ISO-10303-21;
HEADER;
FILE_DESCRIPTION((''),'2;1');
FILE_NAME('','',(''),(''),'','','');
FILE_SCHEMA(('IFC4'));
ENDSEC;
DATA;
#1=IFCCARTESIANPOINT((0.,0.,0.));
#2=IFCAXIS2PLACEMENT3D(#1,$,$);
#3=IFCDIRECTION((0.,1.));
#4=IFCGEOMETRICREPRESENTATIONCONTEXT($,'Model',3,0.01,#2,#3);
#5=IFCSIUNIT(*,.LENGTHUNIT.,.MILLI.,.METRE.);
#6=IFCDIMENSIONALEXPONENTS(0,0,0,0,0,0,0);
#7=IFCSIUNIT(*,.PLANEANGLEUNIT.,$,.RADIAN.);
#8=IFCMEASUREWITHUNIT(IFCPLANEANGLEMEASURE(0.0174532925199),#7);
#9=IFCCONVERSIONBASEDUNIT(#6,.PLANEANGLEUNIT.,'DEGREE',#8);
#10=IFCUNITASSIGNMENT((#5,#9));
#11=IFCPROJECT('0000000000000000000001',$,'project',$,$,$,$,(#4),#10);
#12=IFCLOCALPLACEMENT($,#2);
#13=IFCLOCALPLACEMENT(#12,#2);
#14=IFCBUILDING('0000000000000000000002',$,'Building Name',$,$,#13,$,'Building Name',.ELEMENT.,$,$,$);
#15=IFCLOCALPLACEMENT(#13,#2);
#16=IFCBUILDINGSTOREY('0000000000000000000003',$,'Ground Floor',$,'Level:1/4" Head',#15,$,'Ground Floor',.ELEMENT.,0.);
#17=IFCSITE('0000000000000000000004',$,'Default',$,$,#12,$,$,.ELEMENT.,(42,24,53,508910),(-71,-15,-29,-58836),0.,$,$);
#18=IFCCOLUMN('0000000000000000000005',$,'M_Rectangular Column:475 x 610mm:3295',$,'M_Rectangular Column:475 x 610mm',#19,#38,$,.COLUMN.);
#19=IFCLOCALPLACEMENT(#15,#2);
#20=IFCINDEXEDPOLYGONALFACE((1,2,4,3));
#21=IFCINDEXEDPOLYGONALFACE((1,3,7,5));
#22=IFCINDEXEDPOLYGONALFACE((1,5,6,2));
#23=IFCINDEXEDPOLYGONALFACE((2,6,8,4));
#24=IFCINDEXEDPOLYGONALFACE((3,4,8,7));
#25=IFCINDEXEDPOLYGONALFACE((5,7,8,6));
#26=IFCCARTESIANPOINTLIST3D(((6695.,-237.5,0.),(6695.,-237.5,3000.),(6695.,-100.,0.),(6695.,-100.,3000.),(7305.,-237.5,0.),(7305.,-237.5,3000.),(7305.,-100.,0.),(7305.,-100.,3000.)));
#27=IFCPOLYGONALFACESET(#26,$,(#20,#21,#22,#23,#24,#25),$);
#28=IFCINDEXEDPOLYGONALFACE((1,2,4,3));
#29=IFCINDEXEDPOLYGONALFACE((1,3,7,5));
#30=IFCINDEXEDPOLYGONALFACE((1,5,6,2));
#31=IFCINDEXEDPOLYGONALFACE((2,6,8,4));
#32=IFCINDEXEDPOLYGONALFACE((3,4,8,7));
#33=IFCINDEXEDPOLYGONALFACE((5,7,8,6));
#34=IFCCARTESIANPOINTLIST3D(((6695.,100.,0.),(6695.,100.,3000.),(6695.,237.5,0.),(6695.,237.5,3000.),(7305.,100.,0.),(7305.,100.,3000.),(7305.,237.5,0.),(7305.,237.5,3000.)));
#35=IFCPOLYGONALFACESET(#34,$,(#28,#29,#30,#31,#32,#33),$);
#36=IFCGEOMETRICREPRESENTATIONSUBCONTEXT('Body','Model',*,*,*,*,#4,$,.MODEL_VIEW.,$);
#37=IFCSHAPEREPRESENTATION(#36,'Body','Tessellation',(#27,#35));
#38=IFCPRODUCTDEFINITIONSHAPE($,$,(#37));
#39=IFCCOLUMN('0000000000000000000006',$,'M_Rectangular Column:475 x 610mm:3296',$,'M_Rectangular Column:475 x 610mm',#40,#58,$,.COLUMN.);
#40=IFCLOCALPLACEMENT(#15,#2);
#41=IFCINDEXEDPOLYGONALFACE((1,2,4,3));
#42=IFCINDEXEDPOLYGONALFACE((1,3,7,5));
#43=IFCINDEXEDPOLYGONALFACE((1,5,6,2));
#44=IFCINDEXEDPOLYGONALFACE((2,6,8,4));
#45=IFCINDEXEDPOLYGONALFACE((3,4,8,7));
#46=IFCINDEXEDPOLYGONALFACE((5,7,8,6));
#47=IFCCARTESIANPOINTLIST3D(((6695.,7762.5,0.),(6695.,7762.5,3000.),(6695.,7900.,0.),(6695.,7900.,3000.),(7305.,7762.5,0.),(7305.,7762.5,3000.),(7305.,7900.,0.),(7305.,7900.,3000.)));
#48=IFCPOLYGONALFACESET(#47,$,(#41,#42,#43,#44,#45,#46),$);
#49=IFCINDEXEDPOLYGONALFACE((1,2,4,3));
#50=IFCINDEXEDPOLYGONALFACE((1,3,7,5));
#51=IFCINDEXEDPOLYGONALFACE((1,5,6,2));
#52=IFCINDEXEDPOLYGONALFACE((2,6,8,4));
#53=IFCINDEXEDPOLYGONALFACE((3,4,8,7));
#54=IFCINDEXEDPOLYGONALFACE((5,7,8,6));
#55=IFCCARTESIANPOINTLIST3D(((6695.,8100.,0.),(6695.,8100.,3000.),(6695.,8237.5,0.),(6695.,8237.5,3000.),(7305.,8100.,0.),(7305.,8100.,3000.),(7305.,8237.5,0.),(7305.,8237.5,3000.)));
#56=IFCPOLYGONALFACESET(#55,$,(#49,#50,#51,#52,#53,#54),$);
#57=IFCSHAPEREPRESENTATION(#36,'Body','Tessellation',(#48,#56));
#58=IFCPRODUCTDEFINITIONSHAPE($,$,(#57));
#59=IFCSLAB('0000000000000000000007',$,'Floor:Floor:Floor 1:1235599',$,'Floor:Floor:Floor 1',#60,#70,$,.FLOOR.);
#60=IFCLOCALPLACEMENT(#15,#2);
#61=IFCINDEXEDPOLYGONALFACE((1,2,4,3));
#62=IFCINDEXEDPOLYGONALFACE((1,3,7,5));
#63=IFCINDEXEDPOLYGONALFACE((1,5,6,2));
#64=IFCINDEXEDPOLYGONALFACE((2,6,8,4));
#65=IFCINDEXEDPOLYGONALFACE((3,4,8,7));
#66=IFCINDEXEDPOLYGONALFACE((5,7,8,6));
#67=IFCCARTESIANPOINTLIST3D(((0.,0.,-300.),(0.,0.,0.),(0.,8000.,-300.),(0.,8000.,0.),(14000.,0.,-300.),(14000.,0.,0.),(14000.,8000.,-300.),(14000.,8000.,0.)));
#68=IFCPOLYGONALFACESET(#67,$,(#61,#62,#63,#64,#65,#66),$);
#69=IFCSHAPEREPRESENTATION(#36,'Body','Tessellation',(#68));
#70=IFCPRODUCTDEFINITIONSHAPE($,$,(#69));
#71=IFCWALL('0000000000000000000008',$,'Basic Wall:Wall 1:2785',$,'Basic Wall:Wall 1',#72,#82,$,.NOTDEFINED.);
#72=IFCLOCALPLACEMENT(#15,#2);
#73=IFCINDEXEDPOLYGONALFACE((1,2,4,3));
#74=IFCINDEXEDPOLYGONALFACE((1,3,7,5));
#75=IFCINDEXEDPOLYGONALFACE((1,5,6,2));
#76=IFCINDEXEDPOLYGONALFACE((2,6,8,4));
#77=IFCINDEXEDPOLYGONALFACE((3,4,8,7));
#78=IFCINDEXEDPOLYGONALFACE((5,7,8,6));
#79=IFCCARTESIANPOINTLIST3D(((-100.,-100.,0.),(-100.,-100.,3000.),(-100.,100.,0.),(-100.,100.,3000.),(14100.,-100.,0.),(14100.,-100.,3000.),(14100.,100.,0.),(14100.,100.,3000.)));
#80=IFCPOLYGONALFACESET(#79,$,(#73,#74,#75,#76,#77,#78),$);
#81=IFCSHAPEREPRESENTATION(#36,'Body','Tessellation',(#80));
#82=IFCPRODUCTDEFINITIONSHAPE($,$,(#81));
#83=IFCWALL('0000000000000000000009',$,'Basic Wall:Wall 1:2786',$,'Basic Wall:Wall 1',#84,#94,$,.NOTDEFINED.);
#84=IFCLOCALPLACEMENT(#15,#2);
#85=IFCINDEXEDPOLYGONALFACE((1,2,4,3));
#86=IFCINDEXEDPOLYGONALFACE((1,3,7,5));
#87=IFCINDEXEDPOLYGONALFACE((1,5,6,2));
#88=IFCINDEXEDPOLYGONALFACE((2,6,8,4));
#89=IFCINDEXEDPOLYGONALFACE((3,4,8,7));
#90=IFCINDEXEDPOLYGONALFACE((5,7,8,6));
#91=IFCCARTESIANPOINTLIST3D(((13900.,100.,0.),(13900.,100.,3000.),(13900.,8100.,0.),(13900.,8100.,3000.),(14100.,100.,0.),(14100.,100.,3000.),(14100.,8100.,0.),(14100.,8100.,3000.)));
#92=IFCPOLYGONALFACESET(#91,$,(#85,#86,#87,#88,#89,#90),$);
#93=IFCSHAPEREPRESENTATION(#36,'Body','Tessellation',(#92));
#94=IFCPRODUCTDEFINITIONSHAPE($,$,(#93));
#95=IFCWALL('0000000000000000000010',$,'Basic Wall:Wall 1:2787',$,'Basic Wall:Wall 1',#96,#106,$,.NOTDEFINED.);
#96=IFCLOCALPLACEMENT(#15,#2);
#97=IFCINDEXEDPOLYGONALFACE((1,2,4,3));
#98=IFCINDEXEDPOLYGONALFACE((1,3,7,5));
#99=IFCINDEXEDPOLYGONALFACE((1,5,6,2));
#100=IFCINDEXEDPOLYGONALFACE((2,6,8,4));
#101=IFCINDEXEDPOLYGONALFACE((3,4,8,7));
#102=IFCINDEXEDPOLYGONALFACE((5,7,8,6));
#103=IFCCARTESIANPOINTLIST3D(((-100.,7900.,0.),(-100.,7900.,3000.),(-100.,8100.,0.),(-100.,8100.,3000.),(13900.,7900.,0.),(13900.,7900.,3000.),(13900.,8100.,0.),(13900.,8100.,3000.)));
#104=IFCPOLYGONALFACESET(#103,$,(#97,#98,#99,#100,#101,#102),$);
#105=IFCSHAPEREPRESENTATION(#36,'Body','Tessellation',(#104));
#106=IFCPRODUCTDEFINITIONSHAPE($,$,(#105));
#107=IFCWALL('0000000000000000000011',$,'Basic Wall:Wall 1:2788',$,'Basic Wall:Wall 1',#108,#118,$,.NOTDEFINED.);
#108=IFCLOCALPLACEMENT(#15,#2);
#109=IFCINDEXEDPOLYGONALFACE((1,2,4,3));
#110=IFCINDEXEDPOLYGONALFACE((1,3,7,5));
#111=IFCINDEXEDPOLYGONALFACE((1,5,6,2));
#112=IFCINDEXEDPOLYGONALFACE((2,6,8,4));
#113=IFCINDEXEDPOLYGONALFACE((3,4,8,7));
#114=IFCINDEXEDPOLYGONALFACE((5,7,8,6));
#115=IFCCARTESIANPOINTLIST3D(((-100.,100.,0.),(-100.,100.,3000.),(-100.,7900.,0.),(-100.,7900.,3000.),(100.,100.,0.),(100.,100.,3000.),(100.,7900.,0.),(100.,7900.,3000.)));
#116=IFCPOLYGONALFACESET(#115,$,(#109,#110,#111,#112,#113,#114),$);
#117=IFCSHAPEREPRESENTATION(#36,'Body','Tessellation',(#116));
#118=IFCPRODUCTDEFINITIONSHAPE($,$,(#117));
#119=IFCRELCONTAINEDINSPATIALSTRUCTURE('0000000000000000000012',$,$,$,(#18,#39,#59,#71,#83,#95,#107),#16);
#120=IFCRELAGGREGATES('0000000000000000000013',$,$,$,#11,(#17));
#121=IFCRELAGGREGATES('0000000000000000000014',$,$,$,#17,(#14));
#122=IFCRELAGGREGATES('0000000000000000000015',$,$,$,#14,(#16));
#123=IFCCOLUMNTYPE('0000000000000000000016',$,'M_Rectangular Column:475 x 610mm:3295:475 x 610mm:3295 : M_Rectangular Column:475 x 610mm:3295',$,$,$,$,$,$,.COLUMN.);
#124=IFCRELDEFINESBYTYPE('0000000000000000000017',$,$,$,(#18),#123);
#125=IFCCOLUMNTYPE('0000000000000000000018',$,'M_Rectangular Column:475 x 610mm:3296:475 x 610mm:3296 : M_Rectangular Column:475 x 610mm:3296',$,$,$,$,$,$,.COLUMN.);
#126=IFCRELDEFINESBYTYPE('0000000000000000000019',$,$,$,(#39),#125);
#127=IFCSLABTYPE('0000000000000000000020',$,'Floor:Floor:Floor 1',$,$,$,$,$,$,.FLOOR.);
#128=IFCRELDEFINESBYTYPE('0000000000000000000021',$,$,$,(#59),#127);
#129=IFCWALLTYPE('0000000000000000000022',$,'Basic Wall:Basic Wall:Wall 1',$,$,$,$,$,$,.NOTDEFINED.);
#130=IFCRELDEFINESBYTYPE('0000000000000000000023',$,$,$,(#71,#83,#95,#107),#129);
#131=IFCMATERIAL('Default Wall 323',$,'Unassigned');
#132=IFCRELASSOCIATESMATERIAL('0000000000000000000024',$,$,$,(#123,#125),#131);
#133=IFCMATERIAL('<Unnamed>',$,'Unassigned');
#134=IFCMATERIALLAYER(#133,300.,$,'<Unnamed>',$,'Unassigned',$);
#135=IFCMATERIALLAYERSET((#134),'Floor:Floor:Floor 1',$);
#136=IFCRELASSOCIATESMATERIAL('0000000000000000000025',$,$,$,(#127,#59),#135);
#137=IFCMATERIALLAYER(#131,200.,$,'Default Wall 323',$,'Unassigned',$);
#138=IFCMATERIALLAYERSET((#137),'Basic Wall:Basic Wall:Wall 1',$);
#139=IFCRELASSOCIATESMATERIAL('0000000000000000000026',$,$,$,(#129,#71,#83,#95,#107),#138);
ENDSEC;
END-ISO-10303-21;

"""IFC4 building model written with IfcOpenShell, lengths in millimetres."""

from ifc_helpers import new_model, entity, si_unit, converted_unit, direction, frame, frame_2d, origin, origin_2d_with_axis, place, context, subcontext, project, spatial, rectangle, extrude, source, transform, mapped, material, layer, layer_set, layer_usage, material_profile, profile_set, type_object, type_shapes, element, save


model = new_model("IFC4")

# Units and contexts
model_context = context("Model", 3, precision=0.01, world=origin(), true_north=direction((0.0, 1.0)))
body_context = subcontext(model_context, "Body", "Model", "MODEL_VIEW")
ifc_project = project(units=[si_unit("LENGTHUNIT", "METRE", prefix="MILLI"), converted_unit("PLANEANGLEUNIT", "DEGREE", entity("IfcPlaneAngleMeasure", 0.0174532925199), si_unit("PLANEANGLEUNIT", "RADIAN"), dimensions=[0, 0, 0, 0, 0, 0, 0])], contexts=[model_context])

# Site, building, storey
site_placement = place(None, origin())
site = spatial("IfcSite", under=ifc_project, at=site_placement, Name="Default", CompositionType="ELEMENT", RefLatitude=(42, 24, 53, 508910), RefLongitude=(-71, -15, -29, -58836), RefElevation=0.0)
building_placement = place(site_placement, origin())
building = spatial("IfcBuilding", under=site, at=building_placement, Name="Building Name", LongName="Building Name", CompositionType="ELEMENT")
storey_placement = place(building_placement, origin())
storey = spatial("IfcBuildingStorey", under=building, at=storey_placement, Name="Ground Floor", ObjectType="Level:1/4\" Head", LongName="Ground Floor", CompositionType="ELEMENT", Elevation=0.0)

# Columns
ifc_material_1 = material(Name="Default Wall 323", Category="Unassigned")
ifc_material_profile_1 = material_profile(ifc_material_1, rectangle(XDim=610.0, YDim=137.5, at=origin_2d_with_axis()), Name="475 x 610mm:3295 : M_Rectangular Column:475 x 610mm:3295")
ifc_material_profile_2 = material_profile(ifc_material_1, rectangle(XDim=610.0, YDim=137.5, at=frame_2d((0.0, 0.0), x_axis=(1.0, 0.0))), Name="475 x 610mm:3295 : M_Rectangular Column:475 x 610mm:3295")
ifc_profile_set_1 = profile_set([ifc_material_profile_1, ifc_material_profile_2], Name="475 x 610mm:3295 : M_Rectangular Column:475 x 610mm:3295")
column_type_1 = type_object("IfcColumnType", Name="M_Rectangular Column:475 x 610mm:3295:475 x 610mm:3295 : M_Rectangular Column:475 x 610mm:3295", PredefinedType="COLUMN", material=ifc_profile_set_1)
shared_shape_1 = source(origin(), body_context, "Body", "SweptSolid", [
    extrude(rectangle(XDim=610.0, YDim=137.5, at=origin_2d_with_axis()), frame((7000.0, -168.8, 0.0), z_axis=(0.0, 0.0, 1.0), x_axis=(-1.0, 0.0, 0.0)), (0.0, 0.0, 1.0), 3000.0),
    extrude(rectangle(XDim=610.0, YDim=137.5, at=frame_2d((0.0, 0.0), x_axis=(1.0, 0.0))), frame((7000.0, 168.8, 0.0)), (0.0, 0.0, 1.0), 3000.0),
])
type_shapes(column_type_1, [shared_shape_1])
column_1_placement = place(storey_placement, origin())
element("IfcColumn", 1, at=column_1_placement, inside=storey, type_object=column_type_1, Name="M_Rectangular Column:475 x 610mm:3295", ObjectType="M_Rectangular Column:475 x 610mm", PredefinedType="COLUMN", context=body_context, shape_type="MappedRepresentation", body=[
    mapped(shared_shape_1, transform((0.0, 0.0, 0.0), scale=1.0)),
])
ifc_material_profile_3 = material_profile(ifc_material_1, rectangle(XDim=610.0, YDim=137.5, at=frame_2d((0.0, 0.0), x_axis=(1.0, 0.0))), Name="475 x 610mm:3296 : M_Rectangular Column:475 x 610mm:3296")
ifc_material_profile_4 = material_profile(ifc_material_1, rectangle(XDim=610.0, YDim=137.5, at=frame_2d((0.0, 0.0), x_axis=(1.0, 0.0))), Name="475 x 610mm:3296 : M_Rectangular Column:475 x 610mm:3296")
ifc_profile_set_2 = profile_set([ifc_material_profile_3, ifc_material_profile_4], Name="475 x 610mm:3296 : M_Rectangular Column:475 x 610mm:3296")
column_type_2 = type_object("IfcColumnType", Name="M_Rectangular Column:475 x 610mm:3296:475 x 610mm:3296 : M_Rectangular Column:475 x 610mm:3296", PredefinedType="COLUMN", material=ifc_profile_set_2)
shared_shape_2 = source(origin(), body_context, "Body", "SweptSolid", [
    extrude(rectangle(XDim=610.0, YDim=137.5, at=frame_2d((0.0, 0.0), x_axis=(1.0, 0.0))), frame((7000.0, 7831.2, 0.0), z_axis=(0.0, 0.0, 1.0), x_axis=(-1.0, 0.0, 0.0)), (0.0, 0.0, 1.0), 3000.0),
    extrude(rectangle(XDim=610.0, YDim=137.5, at=frame_2d((0.0, 0.0), x_axis=(1.0, 0.0))), frame((7000.0, 8168.8, 0.0)), (0.0, 0.0, 1.0), 3000.0),
])
type_shapes(column_type_2, [shared_shape_2])
column_2_placement = place(storey_placement, origin())
element("IfcColumn", 2, at=column_2_placement, inside=storey, type_object=column_type_2, Name="M_Rectangular Column:475 x 610mm:3296", ObjectType="M_Rectangular Column:475 x 610mm", PredefinedType="COLUMN", context=body_context, shape_type="MappedRepresentation", body=[
    mapped(shared_shape_2, transform((0.0, 0.0, 0.0), scale=1.0)),
])

# Slab
ifc_material_2 = material(Name="<Unnamed>", Category="Unassigned")
ifc_layer_1 = layer(ifc_material_2, 300.0, Name="<Unnamed>", Category="Unassigned")
ifc_layer_set_1 = layer_set([ifc_layer_1], Name="Floor:Floor:Floor 1")
ifc_layer_usage_1 = layer_usage(ifc_layer_set_1, "AXIS3", "POSITIVE", 0.0)
slab_type = type_object("IfcSlabType", Name="Floor:Floor:Floor 1", PredefinedType="FLOOR", material=ifc_layer_set_1)
slab_placement = place(storey_placement, origin())
element("IfcSlab", 3, at=slab_placement, inside=storey, type_object=slab_type, material=ifc_layer_usage_1, Name="Floor:Floor:Floor 1:1235599", ObjectType="Floor:Floor:Floor 1", PredefinedType="FLOOR", context=body_context, shape_type="SweptSolid", body=[
    extrude(rectangle(XDim=8000.0, YDim=14000.0, at=origin_2d_with_axis()), frame((7000.0, 4000.0, 0.0), z_axis=(0.0, 0.0, -1.0), x_axis=(0.0, 1.0, 0.0)), (0.0, 0.0, 1.0), 300.0),
])

# Walls
ifc_layer_2 = layer(ifc_material_1, 200.0, Name="Default Wall 323", Category="Unassigned")
ifc_layer_set_2 = layer_set([ifc_layer_2], Name="Basic Wall:Basic Wall:Wall 1")
ifc_layer_usage_2 = layer_usage(ifc_layer_set_2, "AXIS2", "NEGATIVE", 100.0)
wall_type = type_object("IfcWallType", Name="Basic Wall:Basic Wall:Wall 1", PredefinedType="NOTDEFINED", material=ifc_layer_set_2)
wall_1_placement = place(storey_placement, frame((-100.0, 0.0, 0.0)))
element("IfcWall", 4, at=wall_1_placement, inside=storey, type_object=wall_type, material=ifc_layer_usage_2, Name="Basic Wall:Wall 1:2785", ObjectType="Basic Wall:Wall 1", PredefinedType="NOTDEFINED", context=body_context, shape_type="SweptSolid", body=[
    extrude(rectangle(XDim=14200.0, YDim=200.0, at=frame_2d((7100.0, 0.0), x_axis=(-1.0, 0.0))), origin(), (0.0, 0.0, 1.0), 3000.0),
])
ifc_layer_usage_3 = layer_usage(ifc_layer_set_2, "AXIS2", "NEGATIVE", 100.0)
wall_2_placement = place(storey_placement, frame((14000.0, 100.0, 0.0), z_axis=(0.0, 0.0, 1.0), x_axis=(0.0, 1.0, 0.0)))
element("IfcWall", 5, at=wall_2_placement, inside=storey, type_object=wall_type, material=ifc_layer_usage_3, Name="Basic Wall:Wall 1:2786", ObjectType="Basic Wall:Wall 1", PredefinedType="NOTDEFINED", context=body_context, shape_type="SweptSolid", body=[
    extrude(rectangle(XDim=8000.0, YDim=200.0, at=frame_2d((4000.0, 0.0), x_axis=(-1.0, 0.0))), origin(), (0.0, 0.0, 1.0), 3000.0),
])
ifc_layer_usage_4 = layer_usage(ifc_layer_set_2, "AXIS2", "NEGATIVE", 100.0)
wall_3_placement = place(storey_placement, frame((13900.0, 8000.0, 0.0), z_axis=(0.0, 0.0, 1.0), x_axis=(-1.0, 0.0, 0.0)))
element("IfcWall", 6, at=wall_3_placement, inside=storey, type_object=wall_type, material=ifc_layer_usage_4, Name="Basic Wall:Wall 1:2787", ObjectType="Basic Wall:Wall 1", PredefinedType="NOTDEFINED", context=body_context, shape_type="SweptSolid", body=[
    extrude(rectangle(XDim=14000.0, YDim=200.0, at=frame_2d((7000.0, 0.0), x_axis=(-1.0, 0.0))), origin(), (0.0, 0.0, 1.0), 3000.0),
])
ifc_layer_usage_5 = layer_usage(ifc_layer_set_2, "AXIS2", "NEGATIVE", 100.0)
wall_4_placement = place(storey_placement, frame((0.0, 7900.0, 0.0), z_axis=(0.0, 0.0, 1.0), x_axis=(0.0, -1.0, 0.0)))
element("IfcWall", 7, at=wall_4_placement, inside=storey, type_object=wall_type, material=ifc_layer_usage_5, Name="Basic Wall:Wall 1:2788", ObjectType="Basic Wall:Wall 1", PredefinedType="NOTDEFINED", context=body_context, shape_type="SweptSolid", body=[
    extrude(rectangle(XDim=7800.0, YDim=200.0, at=frame_2d((3900.0, 0.0), x_axis=(-1.0, 0.0))), origin(), (0.0, 0.0, 1.0), 3000.0),
])

save(model, "model.ifc")
